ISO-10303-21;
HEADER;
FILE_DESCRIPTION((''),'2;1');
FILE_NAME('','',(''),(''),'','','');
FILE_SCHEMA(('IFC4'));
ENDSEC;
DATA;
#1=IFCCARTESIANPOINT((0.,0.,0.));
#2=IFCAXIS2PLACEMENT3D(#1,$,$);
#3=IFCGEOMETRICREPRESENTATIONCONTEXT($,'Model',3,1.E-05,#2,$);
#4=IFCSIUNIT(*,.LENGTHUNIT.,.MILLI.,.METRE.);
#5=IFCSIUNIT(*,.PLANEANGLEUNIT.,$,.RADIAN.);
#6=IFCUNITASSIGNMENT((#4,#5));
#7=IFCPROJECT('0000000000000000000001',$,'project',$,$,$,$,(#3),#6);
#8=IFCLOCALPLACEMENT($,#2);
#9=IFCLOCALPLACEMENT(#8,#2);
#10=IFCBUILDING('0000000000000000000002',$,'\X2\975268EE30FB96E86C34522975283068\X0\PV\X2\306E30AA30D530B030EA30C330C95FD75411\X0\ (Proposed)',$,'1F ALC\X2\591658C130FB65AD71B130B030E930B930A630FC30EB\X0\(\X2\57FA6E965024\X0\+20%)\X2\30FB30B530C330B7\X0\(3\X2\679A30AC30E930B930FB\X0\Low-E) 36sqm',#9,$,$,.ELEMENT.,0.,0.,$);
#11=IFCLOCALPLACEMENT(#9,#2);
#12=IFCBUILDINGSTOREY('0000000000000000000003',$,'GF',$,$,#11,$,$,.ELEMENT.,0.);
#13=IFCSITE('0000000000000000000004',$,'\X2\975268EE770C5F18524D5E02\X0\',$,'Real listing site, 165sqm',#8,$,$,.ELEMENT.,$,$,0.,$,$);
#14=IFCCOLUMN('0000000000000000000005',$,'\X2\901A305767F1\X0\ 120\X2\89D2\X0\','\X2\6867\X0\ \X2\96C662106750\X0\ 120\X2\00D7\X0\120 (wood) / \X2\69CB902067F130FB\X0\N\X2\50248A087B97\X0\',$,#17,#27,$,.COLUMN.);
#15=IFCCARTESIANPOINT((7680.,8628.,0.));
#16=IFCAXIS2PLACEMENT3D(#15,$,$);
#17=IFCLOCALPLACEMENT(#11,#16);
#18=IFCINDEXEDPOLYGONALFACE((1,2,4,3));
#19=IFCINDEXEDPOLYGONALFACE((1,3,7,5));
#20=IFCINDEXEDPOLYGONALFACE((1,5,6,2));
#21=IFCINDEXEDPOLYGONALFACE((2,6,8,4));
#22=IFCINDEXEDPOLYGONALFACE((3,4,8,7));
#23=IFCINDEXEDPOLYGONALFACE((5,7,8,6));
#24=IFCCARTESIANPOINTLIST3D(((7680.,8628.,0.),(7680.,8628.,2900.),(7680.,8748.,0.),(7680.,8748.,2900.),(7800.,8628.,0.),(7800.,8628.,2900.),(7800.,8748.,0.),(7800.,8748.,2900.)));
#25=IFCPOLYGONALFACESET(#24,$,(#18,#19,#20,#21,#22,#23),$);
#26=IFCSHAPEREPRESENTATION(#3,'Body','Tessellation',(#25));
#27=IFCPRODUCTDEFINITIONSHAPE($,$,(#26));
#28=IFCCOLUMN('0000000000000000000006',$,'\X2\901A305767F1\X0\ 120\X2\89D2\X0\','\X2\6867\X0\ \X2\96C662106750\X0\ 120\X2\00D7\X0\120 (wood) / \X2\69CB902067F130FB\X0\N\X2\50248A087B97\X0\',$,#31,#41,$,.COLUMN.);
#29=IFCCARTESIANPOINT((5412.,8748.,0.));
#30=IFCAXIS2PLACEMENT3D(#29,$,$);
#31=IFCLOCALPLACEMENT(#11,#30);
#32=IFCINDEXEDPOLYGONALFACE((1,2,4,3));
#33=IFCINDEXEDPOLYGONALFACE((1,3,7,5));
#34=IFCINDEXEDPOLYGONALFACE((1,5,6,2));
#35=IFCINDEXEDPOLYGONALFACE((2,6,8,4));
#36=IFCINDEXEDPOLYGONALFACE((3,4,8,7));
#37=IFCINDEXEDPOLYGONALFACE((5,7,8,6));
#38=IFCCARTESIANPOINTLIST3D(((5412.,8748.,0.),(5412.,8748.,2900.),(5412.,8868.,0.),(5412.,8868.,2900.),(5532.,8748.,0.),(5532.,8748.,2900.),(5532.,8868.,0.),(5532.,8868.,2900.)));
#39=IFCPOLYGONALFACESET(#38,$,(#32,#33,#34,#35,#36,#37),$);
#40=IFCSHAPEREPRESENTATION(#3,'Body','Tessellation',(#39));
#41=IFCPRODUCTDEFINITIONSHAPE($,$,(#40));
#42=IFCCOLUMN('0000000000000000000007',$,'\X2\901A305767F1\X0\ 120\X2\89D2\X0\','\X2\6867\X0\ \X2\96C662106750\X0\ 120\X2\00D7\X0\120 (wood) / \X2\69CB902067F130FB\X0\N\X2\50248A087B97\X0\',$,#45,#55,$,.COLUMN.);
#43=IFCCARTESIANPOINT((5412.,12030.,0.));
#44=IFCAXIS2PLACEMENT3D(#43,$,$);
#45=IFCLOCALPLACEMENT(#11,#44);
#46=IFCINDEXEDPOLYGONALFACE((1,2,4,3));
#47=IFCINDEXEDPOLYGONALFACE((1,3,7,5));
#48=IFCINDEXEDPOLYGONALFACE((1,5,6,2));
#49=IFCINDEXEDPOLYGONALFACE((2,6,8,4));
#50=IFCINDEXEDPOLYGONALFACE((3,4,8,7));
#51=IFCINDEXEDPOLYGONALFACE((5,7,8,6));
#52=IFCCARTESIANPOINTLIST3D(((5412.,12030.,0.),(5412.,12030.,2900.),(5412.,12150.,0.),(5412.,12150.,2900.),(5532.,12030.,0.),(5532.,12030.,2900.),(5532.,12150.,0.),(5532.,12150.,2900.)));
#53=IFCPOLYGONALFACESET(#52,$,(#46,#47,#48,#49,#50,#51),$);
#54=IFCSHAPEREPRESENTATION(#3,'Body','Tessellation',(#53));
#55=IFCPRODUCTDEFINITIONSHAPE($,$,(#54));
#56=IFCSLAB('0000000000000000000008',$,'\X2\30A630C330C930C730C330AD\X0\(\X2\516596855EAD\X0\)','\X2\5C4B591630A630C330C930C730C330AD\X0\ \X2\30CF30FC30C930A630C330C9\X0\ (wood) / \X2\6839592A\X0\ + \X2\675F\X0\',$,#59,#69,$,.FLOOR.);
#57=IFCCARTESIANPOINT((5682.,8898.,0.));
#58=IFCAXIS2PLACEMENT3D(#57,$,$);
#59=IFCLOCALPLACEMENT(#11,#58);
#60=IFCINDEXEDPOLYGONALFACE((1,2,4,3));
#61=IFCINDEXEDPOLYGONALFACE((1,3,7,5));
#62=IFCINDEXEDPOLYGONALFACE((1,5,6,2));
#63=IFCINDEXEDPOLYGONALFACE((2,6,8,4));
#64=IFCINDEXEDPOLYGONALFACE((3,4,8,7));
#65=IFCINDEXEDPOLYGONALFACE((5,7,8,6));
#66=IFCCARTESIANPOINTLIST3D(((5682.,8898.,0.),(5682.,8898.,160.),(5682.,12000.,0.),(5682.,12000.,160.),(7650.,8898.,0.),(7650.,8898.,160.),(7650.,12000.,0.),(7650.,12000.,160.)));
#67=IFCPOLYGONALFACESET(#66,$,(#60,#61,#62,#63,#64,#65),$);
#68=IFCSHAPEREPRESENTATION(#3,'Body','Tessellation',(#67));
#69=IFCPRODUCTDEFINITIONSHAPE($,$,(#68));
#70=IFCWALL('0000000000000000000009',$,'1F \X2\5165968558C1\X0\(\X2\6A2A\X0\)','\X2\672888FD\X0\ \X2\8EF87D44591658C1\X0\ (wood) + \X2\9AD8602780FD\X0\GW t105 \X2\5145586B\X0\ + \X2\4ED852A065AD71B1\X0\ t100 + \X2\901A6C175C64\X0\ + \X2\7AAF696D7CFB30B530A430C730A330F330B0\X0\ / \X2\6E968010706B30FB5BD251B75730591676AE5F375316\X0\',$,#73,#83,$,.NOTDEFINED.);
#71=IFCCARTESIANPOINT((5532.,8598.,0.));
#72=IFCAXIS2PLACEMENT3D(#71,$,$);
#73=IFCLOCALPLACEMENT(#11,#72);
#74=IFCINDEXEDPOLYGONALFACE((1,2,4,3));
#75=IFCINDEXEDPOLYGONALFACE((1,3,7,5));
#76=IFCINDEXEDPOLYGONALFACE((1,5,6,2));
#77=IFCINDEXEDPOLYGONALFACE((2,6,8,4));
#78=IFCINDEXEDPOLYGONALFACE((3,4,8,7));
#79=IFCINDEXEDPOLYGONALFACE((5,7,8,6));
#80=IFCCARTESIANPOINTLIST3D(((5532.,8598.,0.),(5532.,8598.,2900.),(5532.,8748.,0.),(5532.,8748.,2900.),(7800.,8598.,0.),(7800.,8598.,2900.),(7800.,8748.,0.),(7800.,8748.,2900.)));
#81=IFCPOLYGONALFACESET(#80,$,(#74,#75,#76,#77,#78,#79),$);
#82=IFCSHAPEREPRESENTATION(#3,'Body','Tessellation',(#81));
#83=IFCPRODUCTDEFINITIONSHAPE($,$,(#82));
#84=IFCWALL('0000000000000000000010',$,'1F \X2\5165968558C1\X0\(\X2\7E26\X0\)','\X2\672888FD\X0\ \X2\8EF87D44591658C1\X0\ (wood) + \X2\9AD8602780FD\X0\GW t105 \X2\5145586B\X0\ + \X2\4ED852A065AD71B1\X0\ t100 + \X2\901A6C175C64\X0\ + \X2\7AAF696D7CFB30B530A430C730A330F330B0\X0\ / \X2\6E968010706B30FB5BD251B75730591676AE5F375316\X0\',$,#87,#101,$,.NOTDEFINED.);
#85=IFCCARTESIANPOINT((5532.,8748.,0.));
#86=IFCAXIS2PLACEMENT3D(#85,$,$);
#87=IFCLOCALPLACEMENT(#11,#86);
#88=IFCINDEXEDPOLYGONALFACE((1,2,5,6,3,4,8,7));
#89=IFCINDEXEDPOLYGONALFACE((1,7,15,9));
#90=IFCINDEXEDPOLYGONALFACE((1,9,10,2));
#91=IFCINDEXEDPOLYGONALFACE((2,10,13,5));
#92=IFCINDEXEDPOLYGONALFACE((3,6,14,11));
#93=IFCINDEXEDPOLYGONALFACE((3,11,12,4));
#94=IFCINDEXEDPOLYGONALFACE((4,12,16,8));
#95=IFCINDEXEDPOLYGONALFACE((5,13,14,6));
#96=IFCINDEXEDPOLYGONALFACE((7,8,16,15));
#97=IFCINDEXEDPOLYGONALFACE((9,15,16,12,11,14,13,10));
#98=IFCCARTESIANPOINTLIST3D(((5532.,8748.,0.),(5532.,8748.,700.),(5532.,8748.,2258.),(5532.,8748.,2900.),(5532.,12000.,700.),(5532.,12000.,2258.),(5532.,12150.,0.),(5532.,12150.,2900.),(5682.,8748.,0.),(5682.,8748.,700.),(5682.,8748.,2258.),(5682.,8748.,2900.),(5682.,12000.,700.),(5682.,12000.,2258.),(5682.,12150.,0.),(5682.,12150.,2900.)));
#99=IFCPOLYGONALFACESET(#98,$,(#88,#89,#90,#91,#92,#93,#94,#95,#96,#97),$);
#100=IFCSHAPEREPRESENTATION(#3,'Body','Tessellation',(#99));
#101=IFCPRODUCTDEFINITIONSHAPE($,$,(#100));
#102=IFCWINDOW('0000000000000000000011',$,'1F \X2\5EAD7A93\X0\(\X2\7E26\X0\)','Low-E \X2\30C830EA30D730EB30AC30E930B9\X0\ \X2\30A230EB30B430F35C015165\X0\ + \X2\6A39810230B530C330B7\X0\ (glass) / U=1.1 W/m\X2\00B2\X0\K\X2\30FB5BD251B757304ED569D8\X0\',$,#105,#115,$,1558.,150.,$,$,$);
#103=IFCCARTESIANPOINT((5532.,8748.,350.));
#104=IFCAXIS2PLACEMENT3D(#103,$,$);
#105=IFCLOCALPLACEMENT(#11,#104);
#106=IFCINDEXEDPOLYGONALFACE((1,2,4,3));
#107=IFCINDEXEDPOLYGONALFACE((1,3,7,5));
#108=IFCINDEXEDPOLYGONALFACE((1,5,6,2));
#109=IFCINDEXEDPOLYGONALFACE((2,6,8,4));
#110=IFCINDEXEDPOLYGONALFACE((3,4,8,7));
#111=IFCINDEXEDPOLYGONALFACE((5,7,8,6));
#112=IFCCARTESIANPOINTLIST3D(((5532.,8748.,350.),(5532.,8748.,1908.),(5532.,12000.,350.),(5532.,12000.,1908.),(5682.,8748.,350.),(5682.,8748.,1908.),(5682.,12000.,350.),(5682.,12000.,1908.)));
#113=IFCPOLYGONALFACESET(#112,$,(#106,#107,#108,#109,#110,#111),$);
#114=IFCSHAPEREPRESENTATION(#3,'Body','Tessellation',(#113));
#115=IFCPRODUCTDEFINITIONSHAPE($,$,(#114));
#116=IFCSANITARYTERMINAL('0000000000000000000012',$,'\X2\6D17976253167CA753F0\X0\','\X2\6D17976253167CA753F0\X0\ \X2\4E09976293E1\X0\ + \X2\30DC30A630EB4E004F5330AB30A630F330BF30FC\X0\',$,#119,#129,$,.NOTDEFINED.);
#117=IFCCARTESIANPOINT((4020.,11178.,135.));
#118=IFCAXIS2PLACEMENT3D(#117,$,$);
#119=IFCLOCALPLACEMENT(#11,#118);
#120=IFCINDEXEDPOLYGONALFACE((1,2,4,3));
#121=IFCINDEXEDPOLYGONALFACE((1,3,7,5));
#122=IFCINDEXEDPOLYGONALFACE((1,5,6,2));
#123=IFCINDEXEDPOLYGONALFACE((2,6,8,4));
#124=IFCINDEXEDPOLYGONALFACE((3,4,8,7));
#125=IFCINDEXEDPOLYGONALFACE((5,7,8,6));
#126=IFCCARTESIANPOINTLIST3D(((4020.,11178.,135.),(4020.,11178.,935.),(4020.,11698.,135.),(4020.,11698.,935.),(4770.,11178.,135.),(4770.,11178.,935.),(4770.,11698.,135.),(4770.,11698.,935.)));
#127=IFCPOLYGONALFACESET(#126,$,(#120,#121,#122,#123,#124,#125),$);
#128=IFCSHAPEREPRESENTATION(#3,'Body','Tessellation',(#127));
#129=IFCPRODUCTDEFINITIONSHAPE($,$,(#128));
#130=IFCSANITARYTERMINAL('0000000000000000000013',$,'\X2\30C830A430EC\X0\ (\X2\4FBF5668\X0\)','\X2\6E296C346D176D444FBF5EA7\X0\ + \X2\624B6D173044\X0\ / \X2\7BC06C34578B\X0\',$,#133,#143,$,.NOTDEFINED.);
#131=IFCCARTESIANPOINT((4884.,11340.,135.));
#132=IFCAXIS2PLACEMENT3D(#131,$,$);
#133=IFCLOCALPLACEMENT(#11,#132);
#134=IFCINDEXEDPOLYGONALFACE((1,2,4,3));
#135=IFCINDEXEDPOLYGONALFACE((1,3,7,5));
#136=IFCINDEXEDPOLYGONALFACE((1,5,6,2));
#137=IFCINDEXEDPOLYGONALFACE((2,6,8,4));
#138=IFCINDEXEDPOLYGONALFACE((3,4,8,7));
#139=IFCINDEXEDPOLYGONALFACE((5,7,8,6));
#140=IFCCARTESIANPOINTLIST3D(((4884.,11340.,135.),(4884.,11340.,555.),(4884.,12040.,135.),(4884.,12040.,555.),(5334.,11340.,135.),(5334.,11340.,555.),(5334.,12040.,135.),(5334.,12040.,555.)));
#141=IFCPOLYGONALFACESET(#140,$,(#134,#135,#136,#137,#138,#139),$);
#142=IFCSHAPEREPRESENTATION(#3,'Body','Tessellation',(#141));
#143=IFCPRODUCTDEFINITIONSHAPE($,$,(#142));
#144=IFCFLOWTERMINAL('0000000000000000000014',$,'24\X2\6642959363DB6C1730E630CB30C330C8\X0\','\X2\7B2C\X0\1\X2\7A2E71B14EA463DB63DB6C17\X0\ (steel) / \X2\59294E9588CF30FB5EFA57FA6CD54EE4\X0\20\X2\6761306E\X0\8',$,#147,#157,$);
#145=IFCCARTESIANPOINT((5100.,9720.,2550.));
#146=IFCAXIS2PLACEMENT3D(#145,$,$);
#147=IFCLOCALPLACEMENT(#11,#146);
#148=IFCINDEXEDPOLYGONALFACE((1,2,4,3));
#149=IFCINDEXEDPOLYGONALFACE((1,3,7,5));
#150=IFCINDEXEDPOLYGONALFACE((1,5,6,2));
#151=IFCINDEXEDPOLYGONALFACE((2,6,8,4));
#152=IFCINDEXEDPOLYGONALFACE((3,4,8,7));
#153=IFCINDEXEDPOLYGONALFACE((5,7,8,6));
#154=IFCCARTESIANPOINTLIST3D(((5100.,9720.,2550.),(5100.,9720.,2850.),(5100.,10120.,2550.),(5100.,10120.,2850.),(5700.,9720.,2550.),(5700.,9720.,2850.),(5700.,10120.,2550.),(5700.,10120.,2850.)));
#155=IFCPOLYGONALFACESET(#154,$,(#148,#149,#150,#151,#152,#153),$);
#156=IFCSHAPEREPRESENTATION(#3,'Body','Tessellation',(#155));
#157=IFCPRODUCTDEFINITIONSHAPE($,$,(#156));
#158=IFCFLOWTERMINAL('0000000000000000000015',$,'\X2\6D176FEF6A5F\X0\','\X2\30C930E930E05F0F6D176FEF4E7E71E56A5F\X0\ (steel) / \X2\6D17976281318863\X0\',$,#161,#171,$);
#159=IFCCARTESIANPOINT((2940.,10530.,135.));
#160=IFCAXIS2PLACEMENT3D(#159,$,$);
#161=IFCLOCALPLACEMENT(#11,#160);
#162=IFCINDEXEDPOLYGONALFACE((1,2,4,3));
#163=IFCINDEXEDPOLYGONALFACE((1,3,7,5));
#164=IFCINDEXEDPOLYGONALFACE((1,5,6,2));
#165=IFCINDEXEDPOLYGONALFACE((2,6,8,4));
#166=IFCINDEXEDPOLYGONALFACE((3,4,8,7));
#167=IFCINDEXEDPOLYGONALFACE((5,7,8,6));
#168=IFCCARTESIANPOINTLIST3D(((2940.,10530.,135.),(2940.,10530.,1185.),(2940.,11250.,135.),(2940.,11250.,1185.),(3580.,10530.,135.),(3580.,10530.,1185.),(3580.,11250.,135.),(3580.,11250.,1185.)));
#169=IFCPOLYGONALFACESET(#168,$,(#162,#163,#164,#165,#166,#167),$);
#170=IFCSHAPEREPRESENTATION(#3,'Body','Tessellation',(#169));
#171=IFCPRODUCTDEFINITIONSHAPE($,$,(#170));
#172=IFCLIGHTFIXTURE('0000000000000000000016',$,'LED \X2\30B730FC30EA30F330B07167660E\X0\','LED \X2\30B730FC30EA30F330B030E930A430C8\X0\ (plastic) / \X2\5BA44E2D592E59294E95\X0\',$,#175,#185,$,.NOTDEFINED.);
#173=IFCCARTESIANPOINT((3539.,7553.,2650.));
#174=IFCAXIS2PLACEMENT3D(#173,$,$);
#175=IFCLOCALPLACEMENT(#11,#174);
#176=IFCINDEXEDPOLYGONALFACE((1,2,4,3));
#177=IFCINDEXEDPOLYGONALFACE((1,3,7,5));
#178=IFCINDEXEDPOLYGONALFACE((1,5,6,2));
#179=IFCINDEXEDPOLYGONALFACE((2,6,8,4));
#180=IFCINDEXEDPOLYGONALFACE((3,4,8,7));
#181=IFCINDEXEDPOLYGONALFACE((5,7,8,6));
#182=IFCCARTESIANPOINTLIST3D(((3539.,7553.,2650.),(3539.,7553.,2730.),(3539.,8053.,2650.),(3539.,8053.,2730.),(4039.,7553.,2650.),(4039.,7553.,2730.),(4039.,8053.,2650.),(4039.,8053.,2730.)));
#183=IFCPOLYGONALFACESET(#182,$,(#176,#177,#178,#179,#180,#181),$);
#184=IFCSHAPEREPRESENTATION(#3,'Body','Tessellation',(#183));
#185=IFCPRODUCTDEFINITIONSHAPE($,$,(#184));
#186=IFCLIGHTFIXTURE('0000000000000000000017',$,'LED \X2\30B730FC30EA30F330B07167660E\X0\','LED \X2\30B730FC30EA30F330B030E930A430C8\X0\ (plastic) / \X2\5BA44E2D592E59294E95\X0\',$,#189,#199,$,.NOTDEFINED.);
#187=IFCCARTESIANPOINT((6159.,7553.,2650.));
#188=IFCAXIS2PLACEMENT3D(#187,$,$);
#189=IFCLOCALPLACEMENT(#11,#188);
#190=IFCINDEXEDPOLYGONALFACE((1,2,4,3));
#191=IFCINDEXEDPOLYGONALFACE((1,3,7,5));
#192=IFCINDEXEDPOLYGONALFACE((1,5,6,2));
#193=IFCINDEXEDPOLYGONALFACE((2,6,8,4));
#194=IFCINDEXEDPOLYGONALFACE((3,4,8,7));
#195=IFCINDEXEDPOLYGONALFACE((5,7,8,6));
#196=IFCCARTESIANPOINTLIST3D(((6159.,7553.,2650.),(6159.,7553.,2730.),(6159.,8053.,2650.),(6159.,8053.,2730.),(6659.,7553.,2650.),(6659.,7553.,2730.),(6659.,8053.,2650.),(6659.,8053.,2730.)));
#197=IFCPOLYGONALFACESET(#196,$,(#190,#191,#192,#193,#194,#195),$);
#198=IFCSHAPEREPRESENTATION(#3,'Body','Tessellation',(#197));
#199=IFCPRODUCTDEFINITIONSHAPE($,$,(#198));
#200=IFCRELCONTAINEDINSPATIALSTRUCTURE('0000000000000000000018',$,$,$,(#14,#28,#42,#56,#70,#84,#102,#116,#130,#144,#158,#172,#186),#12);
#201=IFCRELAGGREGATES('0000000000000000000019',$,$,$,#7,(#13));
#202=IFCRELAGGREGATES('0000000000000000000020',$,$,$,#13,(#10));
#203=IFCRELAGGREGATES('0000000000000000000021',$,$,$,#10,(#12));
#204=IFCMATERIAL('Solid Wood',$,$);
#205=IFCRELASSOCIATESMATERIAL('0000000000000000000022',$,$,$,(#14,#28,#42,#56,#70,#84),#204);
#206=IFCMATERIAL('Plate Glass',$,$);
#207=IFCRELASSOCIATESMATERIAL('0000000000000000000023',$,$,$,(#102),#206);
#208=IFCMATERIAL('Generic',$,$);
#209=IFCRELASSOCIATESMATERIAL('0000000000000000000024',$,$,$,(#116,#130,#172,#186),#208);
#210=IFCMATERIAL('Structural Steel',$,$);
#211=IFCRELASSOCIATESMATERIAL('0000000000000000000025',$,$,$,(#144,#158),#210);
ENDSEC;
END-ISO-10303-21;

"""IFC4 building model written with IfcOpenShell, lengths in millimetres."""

from ifc_helpers import new_model, si_unit, frame, frame_2d, origin, place, context, project, spatial, rectangle, extrude, material, element, fill, save


model = new_model("IFC4")

# Units and contexts
model_context = context("Model", 3, precision=1e-05, world=origin())
ifc_project = project(units=[si_unit("LENGTHUNIT", "METRE", prefix="MILLI"), si_unit("PLANEANGLEUNIT", "RADIAN")], contexts=[model_context])

# Site, building, storey
site_placement = place(None, origin())
site = spatial("IfcSite", under=ifc_project, at=site_placement, Name="青森県弘前市", ObjectType="Real listing site, 165sqm", CompositionType="ELEMENT", RefElevation=0.0)
building_placement = place(site_placement, origin())
building = spatial("IfcBuilding", under=site, at=building_placement, Name="青森・雨水利用とPVのオフグリッド志向 (Proposed)", ObjectType="1F ALC外壁・断熱グラスウール(基準値+20%)・サッシ(3枚ガラス・Low-E) 36sqm", CompositionType="ELEMENT", ElevationOfRefHeight=0.0, ElevationOfTerrain=0.0)
storey_placement = place(building_placement, origin())
storey = spatial("IfcBuildingStorey", under=building, at=storey_placement, Name="GF", CompositionType="ELEMENT", Elevation=0.0)

# Columns
ifc_material_1 = material(Name="Solid Wood")
column_1_placement = place(storey_placement, frame((7680.0, 8628.0, 0.0)))
element("IfcColumn", 1, at=column_1_placement, inside=storey, material=ifc_material_1, Name="通し柱 120角", Description="桧 集成材 120×120 (wood) / 構造柱・N値計算", PredefinedType="COLUMN", context=model_context, shape_type="SweptSolid", body=[
    extrude(rectangle(XDim=120.0, YDim=120.0, at=frame_2d((60.0, 60.0))), frame((7680.0, 8628.0, 0.0)), (0.0, 0.0, 1.0), 2900.0),
])
column_2_placement = place(storey_placement, frame((5412.0, 8748.0, 0.0)))
element("IfcColumn", 2, at=column_2_placement, inside=storey, material=ifc_material_1, Name="通し柱 120角", Description="桧 集成材 120×120 (wood) / 構造柱・N値計算", PredefinedType="COLUMN", context=model_context, shape_type="SweptSolid", body=[
    extrude(rectangle(XDim=120.0, YDim=120.0, at=frame_2d((60.0, 60.0))), frame((5412.0, 8748.0, 0.0)), (0.0, 0.0, 1.0), 2900.0),
])
column_3_placement = place(storey_placement, frame((5412.0, 12030.0, 0.0)))
element("IfcColumn", 3, at=column_3_placement, inside=storey, material=ifc_material_1, Name="通し柱 120角", Description="桧 集成材 120×120 (wood) / 構造柱・N値計算", PredefinedType="COLUMN", context=model_context, shape_type="SweptSolid", body=[
    extrude(rectangle(XDim=120.0, YDim=120.0, at=frame_2d((60.0, 60.0))), frame((5412.0, 12030.0, 0.0)), (0.0, 0.0, 1.0), 2900.0),
])

# Slab
slab_placement = place(storey_placement, frame((5682.0, 8898.0, 0.0)))
element("IfcSlab", 4, at=slab_placement, inside=storey, material=ifc_material_1, Name="ウッドデッキ(入隅庭)", Description="屋外ウッドデッキ ハードウッド (wood) / 根太 + 束", PredefinedType="FLOOR", context=model_context, shape_type="SweptSolid", body=[
    extrude(rectangle(XDim=1968.0, YDim=3102.0, at=frame_2d((984.0, 1551.0))), frame((5682.0, 8898.0, 0.0)), (0.0, 0.0, 1.0), 160.0),
])

# Wall
wall_1_placement = place(storey_placement, frame((5532.0, 8598.0, 0.0)))
element("IfcWall", 5, at=wall_1_placement, inside=storey, material=ifc_material_1, Name="1F 入隅壁(横)", Description="木製 軸組外壁 (wood) + 高性能GW t105 充填 + 付加断熱 t100 + 通気層 + 窯業系サイディング / 準耐火・寒冷地外皮強化", PredefinedType="NOTDEFINED", context=model_context, shape_type="SweptSolid", body=[
    extrude(rectangle(XDim=2268.0, YDim=150.0, at=frame_2d((1134.0, 75.0))), frame((5532.0, 8598.0, 0.0)), (0.0, 0.0, 1.0), 2900.0),
])

# Wall, opening, window
wall_2_placement = place(storey_placement, frame((5532.0, 8748.0, 0.0)))
wall_2 = element("IfcWall", 6, at=wall_2_placement, inside=storey, material=ifc_material_1, Name="1F 入隅壁(縦)", Description="木製 軸組外壁 (wood) + 高性能GW t105 充填 + 付加断熱 t100 + 通気層 + 窯業系サイディング / 準耐火・寒冷地外皮強化", PredefinedType="NOTDEFINED", context=model_context, shape_type="SweptSolid", body=[
    extrude(rectangle(XDim=150.0, YDim=3402.0, at=frame_2d((75.0, 1701.0))), frame((5532.0, 8748.0, 0.0)), (0.0, 0.0, 1.0), 2900.0),
])
opening_placement = place(storey_placement, frame((5532.0, 8748.0, 350.0)))
opening = element("IfcOpeningElement", 7, at=opening_placement, cuts=wall_2, PredefinedType="NOTDEFINED", context=model_context, shape_type="SweptSolid", body=[
    extrude(rectangle(XDim=150.0, YDim=3252.0, at=frame_2d((75.0, 1626.0))), frame((5532.0, 8748.0, 350.0)), (0.0, 0.0, 1.0), 1558.0),
])
ifc_material_2 = material(Name="Plate Glass")
window_placement = place(storey_placement, frame((5532.0, 8748.0, 350.0)))
window = element("IfcWindow", 8, at=window_placement, inside=storey, material=ifc_material_2, Name="1F 庭窓(縦)", Description="Low-E トリプルガラス アルゴン封入 + 樹脂サッシ (glass) / U=1.1 W/m²K・寒冷地仕様", OverallHeight=1558.0, OverallWidth=150.0, context=model_context, shape_type="SweptSolid", body=[
    extrude(rectangle(XDim=150.0, YDim=3252.0, at=frame_2d((75.0, 1626.0))), frame((5532.0, 8748.0, 350.0)), (0.0, 0.0, 1.0), 1558.0),
])
fill(opening, window)

# Sanitary terminals
ifc_material_3 = material(Name="Generic")
sanitary_terminal_1_placement = place(storey_placement, frame((4020.0, 11178.0, 135.0)))
element("IfcSanitaryTerminal", 9, at=sanitary_terminal_1_placement, inside=storey, material=ifc_material_3, Name="洗面化粧台", Description="洗面化粧台 三面鏡 + ボウル一体カウンター", PredefinedType="NOTDEFINED", context=model_context, shape_type="SweptSolid", body=[
    extrude(rectangle(XDim=750.0, YDim=520.0, at=frame_2d((375.0, 260.0))), frame((4020.0, 11178.0, 135.0)), (0.0, 0.0, 1.0), 800.0),
])
sanitary_terminal_2_placement = place(storey_placement, frame((4884.0, 11340.0, 135.0)))
element("IfcSanitaryTerminal", 10, at=sanitary_terminal_2_placement, inside=storey, material=ifc_material_3, Name="トイレ (便器)", Description="温水洗浄便座 + 手洗い / 節水型", PredefinedType="NOTDEFINED", context=model_context, shape_type="SweptSolid", body=[
    extrude(rectangle(XDim=450.0, YDim=700.0, at=frame_2d((225.0, 350.0))), frame((4884.0, 11340.0, 135.0)), (0.0, 0.0, 1.0), 420.0),
])

# Flow terminals
ifc_material_4 = material(Name="Structural Steel")
flow_terminal_1_placement = place(storey_placement, frame((5100.0, 9720.0, 2550.0)))
element("IfcFlowTerminal", 11, at=flow_terminal_1_placement, inside=storey, material=ifc_material_4, Name="24時間換気ユニット", Description="第1種熱交換換気 (steel) / 天井裏・建基法令20条の8", context=model_context, shape_type="SweptSolid", body=[
    extrude(rectangle(XDim=600.0, YDim=400.0, at=frame_2d((300.0, 200.0))), frame((5100.0, 9720.0, 2550.0)), (0.0, 0.0, 1.0), 300.0),
])
flow_terminal_2_placement = place(storey_placement, frame((2940.0, 10530.0, 135.0)))
element("IfcFlowTerminal", 12, at=flow_terminal_2_placement, inside=storey, material=ifc_material_4, Name="洗濯機", Description="ドラム式洗濯乾燥機 (steel) / 洗面脱衣", context=model_context, shape_type="SweptSolid", body=[
    extrude(rectangle(XDim=640.0, YDim=720.0, at=frame_2d((320.0, 360.0))), frame((2940.0, 10530.0, 135.0)), (0.0, 0.0, 1.0), 1050.0),
])

# Light fixtures
light_fixture_1_placement = place(storey_placement, frame((3539.0, 7553.0, 2650.0)))
element("IfcLightFixture", 13, at=light_fixture_1_placement, inside=storey, material=ifc_material_3, Name="LED シーリング照明", Description="LED シーリングライト (plastic) / 室中央天井", PredefinedType="NOTDEFINED", context=model_context, shape_type="SweptSolid", body=[
    extrude(rectangle(XDim=500.0, YDim=500.0, at=frame_2d((250.0, 250.0))), frame((3539.0, 7553.0, 2650.0)), (0.0, 0.0, 1.0), 80.0),
])
light_fixture_2_placement = place(storey_placement, frame((6159.0, 7553.0, 2650.0)))
element("IfcLightFixture", 14, at=light_fixture_2_placement, inside=storey, material=ifc_material_3, Name="LED シーリング照明", Description="LED シーリングライト (plastic) / 室中央天井", PredefinedType="NOTDEFINED", context=model_context, shape_type="SweptSolid", body=[
    extrude(rectangle(XDim=500.0, YDim=500.0, at=frame_2d((250.0, 250.0))), frame((6159.0, 7553.0, 2650.0)), (0.0, 0.0, 1.0), 80.0),
])

save(model, "model.ifc")
